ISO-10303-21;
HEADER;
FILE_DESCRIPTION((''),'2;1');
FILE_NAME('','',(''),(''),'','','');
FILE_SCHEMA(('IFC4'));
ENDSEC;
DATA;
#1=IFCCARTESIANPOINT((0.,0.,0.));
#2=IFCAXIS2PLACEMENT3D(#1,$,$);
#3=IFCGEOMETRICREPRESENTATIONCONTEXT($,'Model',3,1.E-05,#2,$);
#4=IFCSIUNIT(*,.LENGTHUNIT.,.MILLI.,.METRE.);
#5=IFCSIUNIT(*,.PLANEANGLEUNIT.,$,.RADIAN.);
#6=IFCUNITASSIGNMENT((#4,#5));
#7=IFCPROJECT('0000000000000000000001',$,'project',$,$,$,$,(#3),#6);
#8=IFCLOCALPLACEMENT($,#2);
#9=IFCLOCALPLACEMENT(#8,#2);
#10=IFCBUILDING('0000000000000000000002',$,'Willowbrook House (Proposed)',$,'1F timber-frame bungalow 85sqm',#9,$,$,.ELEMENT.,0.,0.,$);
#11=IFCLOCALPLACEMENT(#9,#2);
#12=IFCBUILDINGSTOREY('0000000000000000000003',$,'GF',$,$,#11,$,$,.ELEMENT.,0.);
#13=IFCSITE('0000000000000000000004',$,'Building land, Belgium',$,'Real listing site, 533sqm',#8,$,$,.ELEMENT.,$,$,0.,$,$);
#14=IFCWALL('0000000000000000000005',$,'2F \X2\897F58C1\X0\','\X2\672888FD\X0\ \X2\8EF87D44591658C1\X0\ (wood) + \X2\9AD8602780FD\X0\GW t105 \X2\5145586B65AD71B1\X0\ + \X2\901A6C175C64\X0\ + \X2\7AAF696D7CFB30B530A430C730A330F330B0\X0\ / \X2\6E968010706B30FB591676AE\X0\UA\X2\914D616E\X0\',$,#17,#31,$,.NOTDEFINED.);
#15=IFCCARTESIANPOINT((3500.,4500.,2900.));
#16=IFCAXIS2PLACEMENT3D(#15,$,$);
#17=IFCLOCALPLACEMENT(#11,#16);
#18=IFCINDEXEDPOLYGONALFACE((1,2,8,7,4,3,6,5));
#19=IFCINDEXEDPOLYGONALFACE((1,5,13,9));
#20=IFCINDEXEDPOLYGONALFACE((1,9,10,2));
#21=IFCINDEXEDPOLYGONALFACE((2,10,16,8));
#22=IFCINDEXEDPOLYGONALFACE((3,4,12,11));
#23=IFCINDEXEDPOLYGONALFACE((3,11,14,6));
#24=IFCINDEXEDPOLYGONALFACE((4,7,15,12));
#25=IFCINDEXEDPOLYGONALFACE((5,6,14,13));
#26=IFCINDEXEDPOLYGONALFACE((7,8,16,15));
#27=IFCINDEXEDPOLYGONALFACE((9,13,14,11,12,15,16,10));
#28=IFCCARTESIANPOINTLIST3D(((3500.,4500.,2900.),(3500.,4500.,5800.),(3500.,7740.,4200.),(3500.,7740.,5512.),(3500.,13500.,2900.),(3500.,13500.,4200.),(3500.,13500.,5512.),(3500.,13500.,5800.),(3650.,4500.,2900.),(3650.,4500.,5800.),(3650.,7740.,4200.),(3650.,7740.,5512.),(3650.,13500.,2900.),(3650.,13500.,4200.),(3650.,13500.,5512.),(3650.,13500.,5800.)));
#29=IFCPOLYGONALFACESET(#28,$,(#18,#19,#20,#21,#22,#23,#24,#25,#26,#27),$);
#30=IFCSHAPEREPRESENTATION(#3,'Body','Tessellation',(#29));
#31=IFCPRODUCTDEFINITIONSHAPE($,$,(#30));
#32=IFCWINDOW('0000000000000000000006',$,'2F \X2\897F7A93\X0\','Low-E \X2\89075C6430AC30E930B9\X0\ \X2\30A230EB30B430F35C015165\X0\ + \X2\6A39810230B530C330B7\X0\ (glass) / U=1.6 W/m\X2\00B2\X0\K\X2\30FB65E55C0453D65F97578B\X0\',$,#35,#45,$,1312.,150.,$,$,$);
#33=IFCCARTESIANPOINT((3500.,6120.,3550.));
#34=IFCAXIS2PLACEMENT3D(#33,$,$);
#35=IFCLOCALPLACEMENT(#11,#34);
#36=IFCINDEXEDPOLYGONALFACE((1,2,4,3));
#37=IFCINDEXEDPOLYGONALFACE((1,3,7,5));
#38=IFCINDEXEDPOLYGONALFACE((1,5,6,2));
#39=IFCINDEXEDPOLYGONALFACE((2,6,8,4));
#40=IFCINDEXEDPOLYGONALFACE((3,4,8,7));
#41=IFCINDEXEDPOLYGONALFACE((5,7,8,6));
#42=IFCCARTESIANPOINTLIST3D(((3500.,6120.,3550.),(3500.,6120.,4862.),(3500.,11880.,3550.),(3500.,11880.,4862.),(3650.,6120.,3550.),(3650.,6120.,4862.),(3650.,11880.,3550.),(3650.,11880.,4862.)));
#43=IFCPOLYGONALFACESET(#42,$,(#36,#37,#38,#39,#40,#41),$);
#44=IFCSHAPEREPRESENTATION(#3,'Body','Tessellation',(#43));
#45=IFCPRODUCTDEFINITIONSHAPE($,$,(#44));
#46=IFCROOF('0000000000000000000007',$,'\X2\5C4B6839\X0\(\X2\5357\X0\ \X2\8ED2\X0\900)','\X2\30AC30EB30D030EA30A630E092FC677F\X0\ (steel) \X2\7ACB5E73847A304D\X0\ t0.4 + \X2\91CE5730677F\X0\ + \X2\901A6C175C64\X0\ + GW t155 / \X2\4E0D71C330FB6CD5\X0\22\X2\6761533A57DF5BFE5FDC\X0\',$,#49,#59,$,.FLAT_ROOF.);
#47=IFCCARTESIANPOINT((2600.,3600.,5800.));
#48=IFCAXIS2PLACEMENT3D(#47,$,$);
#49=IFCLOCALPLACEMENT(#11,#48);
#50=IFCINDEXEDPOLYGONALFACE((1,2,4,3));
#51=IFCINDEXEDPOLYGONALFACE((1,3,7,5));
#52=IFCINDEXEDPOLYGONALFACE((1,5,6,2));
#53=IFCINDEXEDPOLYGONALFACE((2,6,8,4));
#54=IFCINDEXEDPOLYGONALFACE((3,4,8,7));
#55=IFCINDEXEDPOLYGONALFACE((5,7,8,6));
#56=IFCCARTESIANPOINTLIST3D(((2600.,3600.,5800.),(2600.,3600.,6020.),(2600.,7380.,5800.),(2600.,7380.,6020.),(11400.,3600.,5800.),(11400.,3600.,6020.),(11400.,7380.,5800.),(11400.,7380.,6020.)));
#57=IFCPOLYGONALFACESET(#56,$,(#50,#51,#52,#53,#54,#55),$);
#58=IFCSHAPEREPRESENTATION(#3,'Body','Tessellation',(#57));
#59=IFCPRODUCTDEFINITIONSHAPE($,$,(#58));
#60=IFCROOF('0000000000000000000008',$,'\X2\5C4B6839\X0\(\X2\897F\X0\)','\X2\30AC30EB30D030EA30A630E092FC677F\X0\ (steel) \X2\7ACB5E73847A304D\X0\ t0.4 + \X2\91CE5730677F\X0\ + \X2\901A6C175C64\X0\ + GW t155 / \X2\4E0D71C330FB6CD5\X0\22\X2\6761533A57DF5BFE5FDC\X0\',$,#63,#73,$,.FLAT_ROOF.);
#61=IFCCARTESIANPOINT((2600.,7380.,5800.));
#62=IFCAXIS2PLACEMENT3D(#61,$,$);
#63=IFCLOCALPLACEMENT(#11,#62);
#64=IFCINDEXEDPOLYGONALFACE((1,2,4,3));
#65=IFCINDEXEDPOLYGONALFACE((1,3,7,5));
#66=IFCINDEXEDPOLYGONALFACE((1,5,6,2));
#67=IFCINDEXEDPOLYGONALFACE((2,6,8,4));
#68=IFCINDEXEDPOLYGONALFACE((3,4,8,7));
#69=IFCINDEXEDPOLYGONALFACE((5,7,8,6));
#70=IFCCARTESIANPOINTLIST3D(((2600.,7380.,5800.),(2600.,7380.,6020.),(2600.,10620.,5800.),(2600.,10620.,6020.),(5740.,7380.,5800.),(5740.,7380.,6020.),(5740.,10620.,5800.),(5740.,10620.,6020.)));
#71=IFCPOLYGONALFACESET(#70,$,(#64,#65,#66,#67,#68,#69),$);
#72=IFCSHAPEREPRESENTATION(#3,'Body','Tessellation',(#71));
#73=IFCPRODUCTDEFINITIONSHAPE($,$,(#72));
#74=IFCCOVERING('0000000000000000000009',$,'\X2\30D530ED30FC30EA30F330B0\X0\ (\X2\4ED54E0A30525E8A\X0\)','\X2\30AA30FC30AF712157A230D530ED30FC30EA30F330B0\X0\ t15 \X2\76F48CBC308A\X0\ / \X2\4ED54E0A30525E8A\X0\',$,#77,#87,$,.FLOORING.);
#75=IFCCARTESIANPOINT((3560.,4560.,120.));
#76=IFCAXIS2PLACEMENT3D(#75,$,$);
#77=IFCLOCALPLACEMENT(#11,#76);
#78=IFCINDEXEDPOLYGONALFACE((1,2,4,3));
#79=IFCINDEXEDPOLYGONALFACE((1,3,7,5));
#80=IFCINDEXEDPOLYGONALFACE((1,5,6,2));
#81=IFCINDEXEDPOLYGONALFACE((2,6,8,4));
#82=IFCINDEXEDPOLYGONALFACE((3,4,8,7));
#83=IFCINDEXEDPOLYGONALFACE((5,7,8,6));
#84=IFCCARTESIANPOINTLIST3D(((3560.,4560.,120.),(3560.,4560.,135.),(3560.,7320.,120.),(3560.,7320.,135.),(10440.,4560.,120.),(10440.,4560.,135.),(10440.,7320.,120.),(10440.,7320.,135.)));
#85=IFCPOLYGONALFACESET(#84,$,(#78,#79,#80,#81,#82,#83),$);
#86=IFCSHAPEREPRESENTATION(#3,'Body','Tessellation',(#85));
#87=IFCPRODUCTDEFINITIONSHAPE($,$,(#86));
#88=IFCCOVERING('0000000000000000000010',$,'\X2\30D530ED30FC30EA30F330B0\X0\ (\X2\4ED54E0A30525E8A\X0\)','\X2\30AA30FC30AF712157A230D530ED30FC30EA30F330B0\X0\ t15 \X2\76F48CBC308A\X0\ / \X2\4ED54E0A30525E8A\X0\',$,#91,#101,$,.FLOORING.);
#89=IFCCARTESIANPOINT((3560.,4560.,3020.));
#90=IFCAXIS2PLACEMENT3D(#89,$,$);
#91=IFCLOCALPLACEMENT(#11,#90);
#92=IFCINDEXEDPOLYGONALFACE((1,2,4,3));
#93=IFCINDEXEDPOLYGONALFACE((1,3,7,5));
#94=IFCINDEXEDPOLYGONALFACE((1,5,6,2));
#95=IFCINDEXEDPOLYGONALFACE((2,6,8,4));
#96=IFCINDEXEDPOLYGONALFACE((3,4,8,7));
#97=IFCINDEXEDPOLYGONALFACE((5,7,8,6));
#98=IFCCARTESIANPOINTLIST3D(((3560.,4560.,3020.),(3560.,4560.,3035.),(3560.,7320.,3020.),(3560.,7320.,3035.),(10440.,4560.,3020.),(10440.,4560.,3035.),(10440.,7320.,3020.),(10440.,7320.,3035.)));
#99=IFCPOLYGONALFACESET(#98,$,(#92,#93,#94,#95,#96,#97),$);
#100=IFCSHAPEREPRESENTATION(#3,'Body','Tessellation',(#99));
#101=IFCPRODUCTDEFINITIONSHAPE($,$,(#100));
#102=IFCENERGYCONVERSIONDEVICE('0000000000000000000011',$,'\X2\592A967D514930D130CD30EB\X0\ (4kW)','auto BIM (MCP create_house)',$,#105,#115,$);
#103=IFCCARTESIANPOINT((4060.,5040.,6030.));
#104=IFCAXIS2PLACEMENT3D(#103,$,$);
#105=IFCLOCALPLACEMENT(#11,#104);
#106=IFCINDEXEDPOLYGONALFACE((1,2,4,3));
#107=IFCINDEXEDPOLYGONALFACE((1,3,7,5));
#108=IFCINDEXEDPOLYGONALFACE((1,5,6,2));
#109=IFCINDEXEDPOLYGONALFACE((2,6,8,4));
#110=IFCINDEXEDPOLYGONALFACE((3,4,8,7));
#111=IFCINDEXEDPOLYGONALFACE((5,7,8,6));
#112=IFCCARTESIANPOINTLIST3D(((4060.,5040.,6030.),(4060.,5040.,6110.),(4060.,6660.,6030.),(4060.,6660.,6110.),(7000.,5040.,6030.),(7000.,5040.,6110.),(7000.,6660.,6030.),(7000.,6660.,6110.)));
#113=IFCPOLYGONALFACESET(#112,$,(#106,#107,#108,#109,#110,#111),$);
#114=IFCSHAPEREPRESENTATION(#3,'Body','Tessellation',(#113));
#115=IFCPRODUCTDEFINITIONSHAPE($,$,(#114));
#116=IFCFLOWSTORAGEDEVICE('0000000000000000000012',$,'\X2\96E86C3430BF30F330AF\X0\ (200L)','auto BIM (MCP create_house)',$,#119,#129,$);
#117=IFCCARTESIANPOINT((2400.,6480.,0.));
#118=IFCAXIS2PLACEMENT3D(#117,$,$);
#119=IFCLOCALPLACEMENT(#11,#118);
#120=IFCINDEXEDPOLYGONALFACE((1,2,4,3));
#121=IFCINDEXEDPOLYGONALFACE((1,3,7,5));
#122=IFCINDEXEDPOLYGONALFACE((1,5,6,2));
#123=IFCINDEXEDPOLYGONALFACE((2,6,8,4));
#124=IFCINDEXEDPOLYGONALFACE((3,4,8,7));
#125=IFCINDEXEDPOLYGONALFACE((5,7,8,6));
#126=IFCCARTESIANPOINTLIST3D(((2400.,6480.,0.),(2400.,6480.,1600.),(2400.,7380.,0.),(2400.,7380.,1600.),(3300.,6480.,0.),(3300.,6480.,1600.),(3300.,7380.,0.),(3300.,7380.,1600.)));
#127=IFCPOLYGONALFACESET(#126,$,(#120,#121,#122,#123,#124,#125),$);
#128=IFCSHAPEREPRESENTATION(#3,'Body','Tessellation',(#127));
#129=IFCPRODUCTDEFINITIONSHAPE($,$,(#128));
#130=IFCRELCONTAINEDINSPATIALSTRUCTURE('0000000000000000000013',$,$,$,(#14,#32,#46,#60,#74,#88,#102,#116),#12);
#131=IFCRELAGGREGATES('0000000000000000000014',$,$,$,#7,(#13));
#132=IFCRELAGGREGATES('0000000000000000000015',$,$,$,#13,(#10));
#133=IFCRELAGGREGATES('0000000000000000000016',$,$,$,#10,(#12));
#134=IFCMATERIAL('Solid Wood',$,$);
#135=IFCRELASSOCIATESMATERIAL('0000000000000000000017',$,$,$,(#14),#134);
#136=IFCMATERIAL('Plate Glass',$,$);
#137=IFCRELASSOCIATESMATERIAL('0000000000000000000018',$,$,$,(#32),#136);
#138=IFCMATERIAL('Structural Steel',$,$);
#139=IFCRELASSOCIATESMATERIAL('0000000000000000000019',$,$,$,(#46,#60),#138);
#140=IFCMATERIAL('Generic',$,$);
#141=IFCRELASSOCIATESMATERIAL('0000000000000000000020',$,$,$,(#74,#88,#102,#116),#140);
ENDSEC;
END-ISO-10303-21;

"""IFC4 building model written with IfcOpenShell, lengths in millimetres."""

from ifc_helpers import new_model, si_unit, frame, frame_2d, origin, place, context, project, spatial, rectangle, extrude, material, element, fill, save


model = new_model("IFC4")

# Units and contexts
model_context = context("Model", 3, precision=1e-05, world=origin())
ifc_project = project(units=[si_unit("LENGTHUNIT", "METRE", prefix="MILLI"), si_unit("PLANEANGLEUNIT", "RADIAN")], contexts=[model_context])

# Site, building, storey
site_placement = place(None, origin())
site = spatial("IfcSite", under=ifc_project, at=site_placement, Name="Building land, Belgium", ObjectType="Real listing site, 533sqm", CompositionType="ELEMENT", RefElevation=0.0)
building_placement = place(site_placement, origin())
building = spatial("IfcBuilding", under=site, at=building_placement, Name="Willowbrook House (Proposed)", ObjectType="1F timber-frame bungalow 85sqm", CompositionType="ELEMENT", ElevationOfRefHeight=0.0, ElevationOfTerrain=0.0)
storey_placement = place(building_placement, origin())
storey = spatial("IfcBuildingStorey", under=building, at=storey_placement, Name="GF", CompositionType="ELEMENT", Elevation=0.0)

# Shared definitions
ifc_material_1 = material(Name="Solid Wood")
ifc_material_2 = material(Name="Generic")

# Shared definitions
ifc_material_3 = material(Name="Plate Glass")

# Wall, opening, window
wall_1_placement = place(storey_placement, frame((3500.0, 4500.0, 2900.0)))
wall_1 = element("IfcWall", 1, at=wall_1_placement, inside=storey, material=ifc_material_1, Name="2F 西壁", Description="木製 軸組外壁 (wood) + 高性能GW t105 充填断熱 + 通気層 + 窯業系サイディング / 準耐火・外皮UA配慮", PredefinedType="NOTDEFINED", context=model_context, shape_type="SweptSolid", body=[
    extrude(rectangle(XDim=150.0, YDim=9000.0, at=frame_2d((75.0, 4500.0))), frame((3500.0, 4500.0, 2900.0)), (0.0, 0.0, 1.0), 2900.0),
])
opening_1_placement = place(storey_placement, frame((3500.0, 6120.0, 3550.0)))
opening_1 = element("IfcOpeningElement", 2, at=opening_1_placement, cuts=wall_1, PredefinedType="NOTDEFINED", context=model_context, shape_type="SweptSolid", body=[
    extrude(rectangle(XDim=150.0, YDim=5760.0, at=frame_2d((75.0, 2880.0))), frame((3500.0, 6120.0, 3550.0)), (0.0, 0.0, 1.0), 1312.0),
])
window_1_placement = place(storey_placement, frame((3500.0, 6120.0, 3550.0)))
window_1 = element("IfcWindow", 3, at=window_1_placement, inside=storey, material=ifc_material_3, Name="2F 西窓", Description="Low-E 複層ガラス アルゴン封入 + 樹脂サッシ (glass) / U=1.6 W/m²K・日射取得型", OverallHeight=1312.0, OverallWidth=150.0, context=model_context, shape_type="SweptSolid", body=[
    extrude(rectangle(XDim=150.0, YDim=5760.0, at=frame_2d((75.0, 2880.0))), frame((3500.0, 6120.0, 3550.0)), (0.0, 0.0, 1.0), 1312.0),
])
fill(opening_1, window_1)

# Roofs
ifc_material_4 = material(Name="Structural Steel")
roof_1_placement = place(storey_placement, frame((2600.0, 3600.0, 5800.0)))
element("IfcRoof", 4, at=roof_1_placement, inside=storey, material=ifc_material_4, Name="屋根(南 軒900)", Description="ガルバリウム鋼板 (steel) 立平葺き t0.4 + 野地板 + 通気層 + GW t155 / 不燃・法22条区域対応", PredefinedType="FLAT_ROOF", context=model_context, shape_type="SweptSolid", body=[
    extrude(rectangle(XDim=8800.0, YDim=3780.0, at=frame_2d((4400.0, 1890.0))), frame((2600.0, 3600.0, 5800.0)), (0.0, 0.0, 1.0), 220.0),
])
roof_2_placement = place(storey_placement, frame((2600.0, 7380.0, 5800.0)))
element("IfcRoof", 5, at=roof_2_placement, inside=storey, material=ifc_material_4, Name="屋根(西)", Description="ガルバリウム鋼板 (steel) 立平葺き t0.4 + 野地板 + 通気層 + GW t155 / 不燃・法22条区域対応", PredefinedType="FLAT_ROOF", context=model_context, shape_type="SweptSolid", body=[
    extrude(rectangle(XDim=3140.0, YDim=3240.0, at=frame_2d((1570.0, 1620.0))), frame((2600.0, 7380.0, 5800.0)), (0.0, 0.0, 1.0), 220.0),
])

# Coverings
covering_1_placement = place(storey_placement, frame((3560.0, 4560.0, 120.0)))
element("IfcCovering", 6, at=covering_1_placement, inside=storey, material=ifc_material_2, Name="フローリング (仕上げ床)", Description="オーク無垢フローリング t15 直貼り / 仕上げ床", PredefinedType="FLOORING", context=model_context, shape_type="SweptSolid", body=[
    extrude(rectangle(XDim=6880.0, YDim=2760.0, at=frame_2d((3440.0, 1380.0))), frame((3560.0, 4560.0, 120.0)), (0.0, 0.0, 1.0), 15.0),
])
covering_2_placement = place(storey_placement, frame((3560.0, 4560.0, 3020.0)))
element("IfcCovering", 7, at=covering_2_placement, inside=storey, material=ifc_material_2, Name="フローリング (仕上げ床)", Description="オーク無垢フローリング t15 直貼り / 仕上げ床", PredefinedType="FLOORING", context=model_context, shape_type="SweptSolid", body=[
    extrude(rectangle(XDim=6880.0, YDim=2760.0, at=frame_2d((3440.0, 1380.0))), frame((3560.0, 4560.0, 3020.0)), (0.0, 0.0, 1.0), 15.0),
])

# Energy conversion device
energy_conversion_device_placement = place(storey_placement, frame((4060.0, 5040.0, 6030.0)))
element("IfcEnergyConversionDevice", 8, at=energy_conversion_device_placement, inside=storey, material=ifc_material_2, Name="太陽光パネル (4kW)", Description="auto BIM (MCP create_house)", context=model_context, shape_type="SweptSolid", body=[
    extrude(rectangle(XDim=2940.0, YDim=1620.0, at=frame_2d((1470.0, 810.0))), frame((4060.0, 5040.0, 6030.0)), (0.0, 0.0, 1.0), 80.0),
])

# Flow storage device
flow_storage_device_placement = place(storey_placement, frame((2400.0, 6480.0, 0.0)))
element("IfcFlowStorageDevice", 9, at=flow_storage_device_placement, inside=storey, material=ifc_material_2, Name="雨水タンク (200L)", Description="auto BIM (MCP create_house)", context=model_context, shape_type="SweptSolid", body=[
    extrude(rectangle(XDim=900.0, YDim=900.0, at=frame_2d((450.0, 450.0))), frame((2400.0, 6480.0, 0.0)), (0.0, 0.0, 1.0), 1600.0),
])

save(model, "model.ifc")
